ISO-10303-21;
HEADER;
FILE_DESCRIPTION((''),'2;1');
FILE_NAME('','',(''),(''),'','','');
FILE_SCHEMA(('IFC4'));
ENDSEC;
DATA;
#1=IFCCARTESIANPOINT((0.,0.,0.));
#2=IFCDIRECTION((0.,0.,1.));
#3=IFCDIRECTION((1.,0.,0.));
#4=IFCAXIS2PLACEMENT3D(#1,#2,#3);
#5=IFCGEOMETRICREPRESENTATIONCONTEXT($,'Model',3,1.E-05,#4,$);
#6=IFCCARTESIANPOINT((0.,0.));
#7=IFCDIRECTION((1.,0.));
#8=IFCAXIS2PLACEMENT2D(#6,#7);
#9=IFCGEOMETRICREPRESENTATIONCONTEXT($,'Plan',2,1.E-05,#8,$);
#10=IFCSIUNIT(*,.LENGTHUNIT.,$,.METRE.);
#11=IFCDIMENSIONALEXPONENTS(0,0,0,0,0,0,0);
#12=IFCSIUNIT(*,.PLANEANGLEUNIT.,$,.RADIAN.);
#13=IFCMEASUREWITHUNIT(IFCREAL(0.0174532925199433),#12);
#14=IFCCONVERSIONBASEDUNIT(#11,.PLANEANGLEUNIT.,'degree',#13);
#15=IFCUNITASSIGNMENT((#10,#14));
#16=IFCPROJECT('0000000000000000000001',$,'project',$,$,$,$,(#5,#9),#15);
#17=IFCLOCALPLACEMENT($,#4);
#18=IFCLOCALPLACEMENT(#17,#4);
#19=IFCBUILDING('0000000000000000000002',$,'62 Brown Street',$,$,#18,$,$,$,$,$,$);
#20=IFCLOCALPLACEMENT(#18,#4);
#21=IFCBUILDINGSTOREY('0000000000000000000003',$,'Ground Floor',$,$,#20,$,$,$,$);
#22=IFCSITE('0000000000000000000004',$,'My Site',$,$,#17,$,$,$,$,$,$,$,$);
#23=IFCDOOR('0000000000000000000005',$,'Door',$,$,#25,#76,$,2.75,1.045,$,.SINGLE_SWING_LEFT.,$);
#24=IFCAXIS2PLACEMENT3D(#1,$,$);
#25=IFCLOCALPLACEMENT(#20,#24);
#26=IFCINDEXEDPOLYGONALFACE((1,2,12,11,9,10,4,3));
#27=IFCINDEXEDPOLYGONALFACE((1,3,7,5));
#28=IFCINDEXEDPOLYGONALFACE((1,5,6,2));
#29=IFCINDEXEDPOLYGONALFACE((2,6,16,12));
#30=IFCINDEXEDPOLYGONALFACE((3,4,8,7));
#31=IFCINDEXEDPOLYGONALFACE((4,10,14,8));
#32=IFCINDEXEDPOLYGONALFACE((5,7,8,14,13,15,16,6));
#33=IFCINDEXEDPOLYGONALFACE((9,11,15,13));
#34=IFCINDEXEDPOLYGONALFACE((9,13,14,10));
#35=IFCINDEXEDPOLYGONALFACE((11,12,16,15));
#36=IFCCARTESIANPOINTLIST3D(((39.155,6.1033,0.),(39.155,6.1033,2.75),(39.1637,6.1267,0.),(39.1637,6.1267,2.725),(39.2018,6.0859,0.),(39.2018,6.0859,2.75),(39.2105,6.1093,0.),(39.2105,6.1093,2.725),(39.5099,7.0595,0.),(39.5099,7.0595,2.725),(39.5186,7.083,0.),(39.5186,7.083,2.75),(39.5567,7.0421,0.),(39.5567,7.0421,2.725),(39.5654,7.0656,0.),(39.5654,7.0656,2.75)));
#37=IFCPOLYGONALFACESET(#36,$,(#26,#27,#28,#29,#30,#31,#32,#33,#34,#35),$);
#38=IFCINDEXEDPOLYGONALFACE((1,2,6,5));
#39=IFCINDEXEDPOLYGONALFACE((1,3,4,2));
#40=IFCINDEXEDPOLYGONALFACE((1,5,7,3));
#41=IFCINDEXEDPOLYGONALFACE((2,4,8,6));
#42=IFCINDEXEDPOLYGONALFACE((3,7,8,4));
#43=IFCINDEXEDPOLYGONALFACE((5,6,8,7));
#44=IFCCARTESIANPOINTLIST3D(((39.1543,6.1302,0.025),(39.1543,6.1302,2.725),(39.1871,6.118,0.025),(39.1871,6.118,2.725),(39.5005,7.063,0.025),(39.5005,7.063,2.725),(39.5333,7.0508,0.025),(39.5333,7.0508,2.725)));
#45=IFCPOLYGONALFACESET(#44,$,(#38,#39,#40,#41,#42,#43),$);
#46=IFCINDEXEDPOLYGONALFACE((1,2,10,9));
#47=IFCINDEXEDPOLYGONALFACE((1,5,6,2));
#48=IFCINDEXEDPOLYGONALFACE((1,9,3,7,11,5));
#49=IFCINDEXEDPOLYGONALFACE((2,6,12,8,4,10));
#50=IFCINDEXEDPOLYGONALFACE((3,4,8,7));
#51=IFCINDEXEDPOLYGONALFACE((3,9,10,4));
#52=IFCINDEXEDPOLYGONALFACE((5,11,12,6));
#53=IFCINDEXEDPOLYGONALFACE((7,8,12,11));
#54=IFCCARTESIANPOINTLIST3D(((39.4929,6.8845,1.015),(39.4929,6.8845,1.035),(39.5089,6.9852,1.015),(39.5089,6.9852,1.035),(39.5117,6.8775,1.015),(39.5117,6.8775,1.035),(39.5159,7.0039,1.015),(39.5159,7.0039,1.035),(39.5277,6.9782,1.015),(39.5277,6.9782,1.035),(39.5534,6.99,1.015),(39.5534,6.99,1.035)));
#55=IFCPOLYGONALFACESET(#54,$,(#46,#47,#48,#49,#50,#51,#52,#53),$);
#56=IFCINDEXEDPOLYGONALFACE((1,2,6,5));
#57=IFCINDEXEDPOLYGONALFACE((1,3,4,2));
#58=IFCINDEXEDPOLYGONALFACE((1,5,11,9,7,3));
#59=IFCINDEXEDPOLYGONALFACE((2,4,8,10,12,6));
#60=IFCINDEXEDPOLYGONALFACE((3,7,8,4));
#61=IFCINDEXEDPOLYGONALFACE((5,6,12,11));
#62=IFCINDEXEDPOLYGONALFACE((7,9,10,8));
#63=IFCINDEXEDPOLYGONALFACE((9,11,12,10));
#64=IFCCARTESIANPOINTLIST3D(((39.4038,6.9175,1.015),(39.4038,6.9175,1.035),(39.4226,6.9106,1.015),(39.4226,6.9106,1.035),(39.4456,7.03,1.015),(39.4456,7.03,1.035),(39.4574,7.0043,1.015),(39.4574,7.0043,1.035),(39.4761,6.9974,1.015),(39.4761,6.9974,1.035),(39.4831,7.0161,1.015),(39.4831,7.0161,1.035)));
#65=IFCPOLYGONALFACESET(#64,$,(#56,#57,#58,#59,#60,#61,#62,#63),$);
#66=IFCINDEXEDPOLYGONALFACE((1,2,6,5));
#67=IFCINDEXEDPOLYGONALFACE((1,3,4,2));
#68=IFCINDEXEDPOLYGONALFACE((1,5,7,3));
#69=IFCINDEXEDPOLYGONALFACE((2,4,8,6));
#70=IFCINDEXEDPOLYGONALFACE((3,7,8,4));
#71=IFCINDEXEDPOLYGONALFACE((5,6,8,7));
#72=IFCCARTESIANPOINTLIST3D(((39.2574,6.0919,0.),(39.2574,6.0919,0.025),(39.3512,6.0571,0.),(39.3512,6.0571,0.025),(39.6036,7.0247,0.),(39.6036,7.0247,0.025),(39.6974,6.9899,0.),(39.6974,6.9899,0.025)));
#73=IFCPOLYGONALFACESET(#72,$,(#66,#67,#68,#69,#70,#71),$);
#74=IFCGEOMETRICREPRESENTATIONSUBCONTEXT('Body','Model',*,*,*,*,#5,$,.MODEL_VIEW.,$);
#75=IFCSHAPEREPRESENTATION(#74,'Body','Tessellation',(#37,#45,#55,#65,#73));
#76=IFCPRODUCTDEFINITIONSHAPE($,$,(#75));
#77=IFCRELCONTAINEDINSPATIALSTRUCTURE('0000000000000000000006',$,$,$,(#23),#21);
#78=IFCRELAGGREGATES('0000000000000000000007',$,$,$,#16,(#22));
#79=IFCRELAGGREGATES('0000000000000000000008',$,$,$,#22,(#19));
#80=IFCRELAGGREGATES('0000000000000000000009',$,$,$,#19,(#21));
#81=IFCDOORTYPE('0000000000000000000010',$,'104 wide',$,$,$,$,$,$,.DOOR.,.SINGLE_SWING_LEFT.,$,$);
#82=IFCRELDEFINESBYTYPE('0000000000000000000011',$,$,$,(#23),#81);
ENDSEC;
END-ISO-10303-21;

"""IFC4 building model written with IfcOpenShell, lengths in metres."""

from ifc_helpers import new_model, entity, si_unit, converted_unit, frame, origin_with_axes, origin_2d_with_axis, place, context, subcontext, project, spatial, line, indexed_curve, outline, extrude, shape, source, transform, mapped, type_object, type_shapes, element, save


model = new_model("IFC4")

# Units and contexts
model_context = context("Model", 3, precision=1e-05, world=origin_with_axes())
plan_context = context("Plan", 2, precision=1e-05, world=origin_2d_with_axis())
body_context_1 = subcontext(model_context, "Body", "Model", "MODEL_VIEW")
body_context_2 = subcontext(plan_context, "Body", "Plan", "PLAN_VIEW")
ifc_project = project(units=[si_unit("LENGTHUNIT", "METRE"), converted_unit("PLANEANGLEUNIT", "degree", entity("IfcReal", 0.0174532925199433), si_unit("PLANEANGLEUNIT", "RADIAN"), dimensions=[0, 0, 0, 0, 0, 0, 0])], contexts=[model_context, plan_context])

# Site, building, storey
site_placement = place(None, origin_with_axes())
site = spatial("IfcSite", under=ifc_project, at=site_placement, Name="My Site")
building_placement = place(site_placement, origin_with_axes())
building = spatial("IfcBuilding", under=site, at=building_placement, Name="62 Brown Street")
storey_placement = place(building_placement, origin_with_axes())
storey = spatial("IfcBuildingStorey", under=building, at=storey_placement, Name="Ground Floor")

# Shared definitions
placement_1 = place(storey_placement, frame((39.024, 5.1755, 0.0), z_axis=(0.0, 0.0, 1.0), x_axis=(0.347944, 0.937515, 0.0)))

# Door
door_type_1 = type_object("IfcDoorType", Name="104 wide", OperationType="SINGLE_SWING_LEFT", PredefinedType="DOOR")
shared_shape_1 = source(origin_with_axes(), body_context_1, "Body", "SweptSolid", [
    extrude(outline(indexed_curve([(0.0, 0.0), (0.0, 2.75), (1.045, 2.75), (1.045, 0.0), (1.02, 0.0), (1.02, 2.725), (0.025, 2.725), (0.025, 0.0)], segments=[line(1, 2, 3, 4, 5, 6, 7, 8, 1)])), frame((0.0, 0.15, 0.0), z_axis=(0.0, -1.0, 0.0), x_axis=(1.0, 0.0, 0.0)), (0.0, 0.0, -1.0), 0.05),
    extrude(outline(indexed_curve([(0.0, 0.0), (0.995, 0.0), (0.995, 0.035), (0.0, 0.035)], segments=[line(1, 2, 3, 4, 1)])), frame((0.025, 0.175, 0.025), z_axis=(0.0, 0.0, 1.0), x_axis=(1.0, 0.0, 0.0)), (0.0, 0.0, 1.0), 2.7),
    extrude(outline(indexed_curve([(0.0, 0.0), (0.0, -0.04), (-0.12, -0.04), (-0.12, -0.02), (-0.02, -0.02), (-0.02, 0.0)], segments=[line(1, 2, 3, 4, 5, 6, 1)])), frame((0.97, 0.175, 1.015), z_axis=(0.0, 0.0, 1.0), x_axis=(1.0, 0.0, 0.0)), (0.0, 0.0, 1.0), 0.02),
    extrude(outline(indexed_curve([(0.0, 0.0), (0.0, 0.04), (-0.12, 0.04), (-0.12, 0.02), (-0.02, 0.02), (-0.02, 0.0)], segments=[line(1, 2, 3, 4, 5, 6, 1)])), frame((0.97, 0.21, 1.015), z_axis=(0.0, 0.0, 1.0), x_axis=(1.0, 0.0, 0.0)), (0.0, 0.0, 1.0), 0.02),
    extrude(outline(indexed_curve([(0.0, 0.0), (0.995, 0.0), (0.995, 0.1), (0.0, 0.1)], segments=[line(1, 2, 3, 4, 1)])), frame((0.025, 0.0, 0.0), z_axis=(0.0, 0.0, 1.0), x_axis=(1.0, 0.0, 0.0)), (0.0, 0.0, 1.0), 0.025),
])
shared_shape_2 = source(origin_with_axes(), body_context_2, "Body", "Curve2D", [
    entity("IfcIndexedPolyCurve", entity("IfcCartesianPointList2D", [[0.0, 0.15], [0.025, 0.15], [0.025, 0.2], [0.0, 0.2]]), [entity("IfcLineIndex", [1, 2, 3, 4, 1])]),
    entity("IfcIndexedPolyCurve", entity("IfcCartesianPointList2D", [[1.045, 0.15], [1.02, 0.15], [1.02, 0.2], [1.045, 0.2]]), [entity("IfcLineIndex", [1, 2, 3, 4, 1])]),
    entity("IfcTrimmedCurve", entity("IfcEllipse", entity("IfcAxis2Placement2D", entity("IfcCartesianPoint", [0.06, 0.2]), entity("IfcDirection", [1.0, 0.0])), 0.96, 0.995), [entity("IfcCartesianPoint", [1.02, 0.2])], [entity("IfcCartesianPoint", [0.06, 1.195])], True, "CARTESIAN"),
    entity("IfcIndexedPolyCurve", entity("IfcCartesianPointList2D", [[0.025, 0.2], [0.06, 0.2], [0.06, 1.195], [0.025, 1.195]]), [entity("IfcLineIndex", [1, 2, 3, 4, 1])]),
])
type_shapes(door_type_1, [shared_shape_1, shared_shape_2])
placement_2 = place(placement_1, frame((0.9154, 0.0, 0.0), z_axis=(0.0, 0.0, 1.0), x_axis=(1.0, 0.0, 0.0)))
door_1_placement = place(placement_2, frame((0.0, 0.0, 0.0), z_axis=(0.0, 0.0, 1.0), x_axis=(1.0, 0.0, 0.0)))
element("IfcDoor", 1, at=door_1_placement, inside=storey, type_object=door_type_1, Name="Door", OperationType="SINGLE_SWING_LEFT", OverallHeight=2.75, OverallWidth=1.045, shapes=[
    shape(body_context_1, "Body", "MappedRepresentation", [mapped(shared_shape_1, transform((0.0, 0.0, 0.0), x_axis=(1.0, 0.0, 0.0), y_axis=(0.0, 1.0, 0.0), z_axis=(0.0, 0.0, 1.0), scale=1.0))]),
    shape(body_context_2, "Body", "MappedRepresentation", [mapped(shared_shape_2, transform((0.0, 0.0, 0.0), x_axis=(1.0, 0.0, 0.0), y_axis=(0.0, 1.0, 0.0), z_axis=(0.0, 0.0, 1.0), scale=1.0))]),
])

save(model, "model.ifc")
